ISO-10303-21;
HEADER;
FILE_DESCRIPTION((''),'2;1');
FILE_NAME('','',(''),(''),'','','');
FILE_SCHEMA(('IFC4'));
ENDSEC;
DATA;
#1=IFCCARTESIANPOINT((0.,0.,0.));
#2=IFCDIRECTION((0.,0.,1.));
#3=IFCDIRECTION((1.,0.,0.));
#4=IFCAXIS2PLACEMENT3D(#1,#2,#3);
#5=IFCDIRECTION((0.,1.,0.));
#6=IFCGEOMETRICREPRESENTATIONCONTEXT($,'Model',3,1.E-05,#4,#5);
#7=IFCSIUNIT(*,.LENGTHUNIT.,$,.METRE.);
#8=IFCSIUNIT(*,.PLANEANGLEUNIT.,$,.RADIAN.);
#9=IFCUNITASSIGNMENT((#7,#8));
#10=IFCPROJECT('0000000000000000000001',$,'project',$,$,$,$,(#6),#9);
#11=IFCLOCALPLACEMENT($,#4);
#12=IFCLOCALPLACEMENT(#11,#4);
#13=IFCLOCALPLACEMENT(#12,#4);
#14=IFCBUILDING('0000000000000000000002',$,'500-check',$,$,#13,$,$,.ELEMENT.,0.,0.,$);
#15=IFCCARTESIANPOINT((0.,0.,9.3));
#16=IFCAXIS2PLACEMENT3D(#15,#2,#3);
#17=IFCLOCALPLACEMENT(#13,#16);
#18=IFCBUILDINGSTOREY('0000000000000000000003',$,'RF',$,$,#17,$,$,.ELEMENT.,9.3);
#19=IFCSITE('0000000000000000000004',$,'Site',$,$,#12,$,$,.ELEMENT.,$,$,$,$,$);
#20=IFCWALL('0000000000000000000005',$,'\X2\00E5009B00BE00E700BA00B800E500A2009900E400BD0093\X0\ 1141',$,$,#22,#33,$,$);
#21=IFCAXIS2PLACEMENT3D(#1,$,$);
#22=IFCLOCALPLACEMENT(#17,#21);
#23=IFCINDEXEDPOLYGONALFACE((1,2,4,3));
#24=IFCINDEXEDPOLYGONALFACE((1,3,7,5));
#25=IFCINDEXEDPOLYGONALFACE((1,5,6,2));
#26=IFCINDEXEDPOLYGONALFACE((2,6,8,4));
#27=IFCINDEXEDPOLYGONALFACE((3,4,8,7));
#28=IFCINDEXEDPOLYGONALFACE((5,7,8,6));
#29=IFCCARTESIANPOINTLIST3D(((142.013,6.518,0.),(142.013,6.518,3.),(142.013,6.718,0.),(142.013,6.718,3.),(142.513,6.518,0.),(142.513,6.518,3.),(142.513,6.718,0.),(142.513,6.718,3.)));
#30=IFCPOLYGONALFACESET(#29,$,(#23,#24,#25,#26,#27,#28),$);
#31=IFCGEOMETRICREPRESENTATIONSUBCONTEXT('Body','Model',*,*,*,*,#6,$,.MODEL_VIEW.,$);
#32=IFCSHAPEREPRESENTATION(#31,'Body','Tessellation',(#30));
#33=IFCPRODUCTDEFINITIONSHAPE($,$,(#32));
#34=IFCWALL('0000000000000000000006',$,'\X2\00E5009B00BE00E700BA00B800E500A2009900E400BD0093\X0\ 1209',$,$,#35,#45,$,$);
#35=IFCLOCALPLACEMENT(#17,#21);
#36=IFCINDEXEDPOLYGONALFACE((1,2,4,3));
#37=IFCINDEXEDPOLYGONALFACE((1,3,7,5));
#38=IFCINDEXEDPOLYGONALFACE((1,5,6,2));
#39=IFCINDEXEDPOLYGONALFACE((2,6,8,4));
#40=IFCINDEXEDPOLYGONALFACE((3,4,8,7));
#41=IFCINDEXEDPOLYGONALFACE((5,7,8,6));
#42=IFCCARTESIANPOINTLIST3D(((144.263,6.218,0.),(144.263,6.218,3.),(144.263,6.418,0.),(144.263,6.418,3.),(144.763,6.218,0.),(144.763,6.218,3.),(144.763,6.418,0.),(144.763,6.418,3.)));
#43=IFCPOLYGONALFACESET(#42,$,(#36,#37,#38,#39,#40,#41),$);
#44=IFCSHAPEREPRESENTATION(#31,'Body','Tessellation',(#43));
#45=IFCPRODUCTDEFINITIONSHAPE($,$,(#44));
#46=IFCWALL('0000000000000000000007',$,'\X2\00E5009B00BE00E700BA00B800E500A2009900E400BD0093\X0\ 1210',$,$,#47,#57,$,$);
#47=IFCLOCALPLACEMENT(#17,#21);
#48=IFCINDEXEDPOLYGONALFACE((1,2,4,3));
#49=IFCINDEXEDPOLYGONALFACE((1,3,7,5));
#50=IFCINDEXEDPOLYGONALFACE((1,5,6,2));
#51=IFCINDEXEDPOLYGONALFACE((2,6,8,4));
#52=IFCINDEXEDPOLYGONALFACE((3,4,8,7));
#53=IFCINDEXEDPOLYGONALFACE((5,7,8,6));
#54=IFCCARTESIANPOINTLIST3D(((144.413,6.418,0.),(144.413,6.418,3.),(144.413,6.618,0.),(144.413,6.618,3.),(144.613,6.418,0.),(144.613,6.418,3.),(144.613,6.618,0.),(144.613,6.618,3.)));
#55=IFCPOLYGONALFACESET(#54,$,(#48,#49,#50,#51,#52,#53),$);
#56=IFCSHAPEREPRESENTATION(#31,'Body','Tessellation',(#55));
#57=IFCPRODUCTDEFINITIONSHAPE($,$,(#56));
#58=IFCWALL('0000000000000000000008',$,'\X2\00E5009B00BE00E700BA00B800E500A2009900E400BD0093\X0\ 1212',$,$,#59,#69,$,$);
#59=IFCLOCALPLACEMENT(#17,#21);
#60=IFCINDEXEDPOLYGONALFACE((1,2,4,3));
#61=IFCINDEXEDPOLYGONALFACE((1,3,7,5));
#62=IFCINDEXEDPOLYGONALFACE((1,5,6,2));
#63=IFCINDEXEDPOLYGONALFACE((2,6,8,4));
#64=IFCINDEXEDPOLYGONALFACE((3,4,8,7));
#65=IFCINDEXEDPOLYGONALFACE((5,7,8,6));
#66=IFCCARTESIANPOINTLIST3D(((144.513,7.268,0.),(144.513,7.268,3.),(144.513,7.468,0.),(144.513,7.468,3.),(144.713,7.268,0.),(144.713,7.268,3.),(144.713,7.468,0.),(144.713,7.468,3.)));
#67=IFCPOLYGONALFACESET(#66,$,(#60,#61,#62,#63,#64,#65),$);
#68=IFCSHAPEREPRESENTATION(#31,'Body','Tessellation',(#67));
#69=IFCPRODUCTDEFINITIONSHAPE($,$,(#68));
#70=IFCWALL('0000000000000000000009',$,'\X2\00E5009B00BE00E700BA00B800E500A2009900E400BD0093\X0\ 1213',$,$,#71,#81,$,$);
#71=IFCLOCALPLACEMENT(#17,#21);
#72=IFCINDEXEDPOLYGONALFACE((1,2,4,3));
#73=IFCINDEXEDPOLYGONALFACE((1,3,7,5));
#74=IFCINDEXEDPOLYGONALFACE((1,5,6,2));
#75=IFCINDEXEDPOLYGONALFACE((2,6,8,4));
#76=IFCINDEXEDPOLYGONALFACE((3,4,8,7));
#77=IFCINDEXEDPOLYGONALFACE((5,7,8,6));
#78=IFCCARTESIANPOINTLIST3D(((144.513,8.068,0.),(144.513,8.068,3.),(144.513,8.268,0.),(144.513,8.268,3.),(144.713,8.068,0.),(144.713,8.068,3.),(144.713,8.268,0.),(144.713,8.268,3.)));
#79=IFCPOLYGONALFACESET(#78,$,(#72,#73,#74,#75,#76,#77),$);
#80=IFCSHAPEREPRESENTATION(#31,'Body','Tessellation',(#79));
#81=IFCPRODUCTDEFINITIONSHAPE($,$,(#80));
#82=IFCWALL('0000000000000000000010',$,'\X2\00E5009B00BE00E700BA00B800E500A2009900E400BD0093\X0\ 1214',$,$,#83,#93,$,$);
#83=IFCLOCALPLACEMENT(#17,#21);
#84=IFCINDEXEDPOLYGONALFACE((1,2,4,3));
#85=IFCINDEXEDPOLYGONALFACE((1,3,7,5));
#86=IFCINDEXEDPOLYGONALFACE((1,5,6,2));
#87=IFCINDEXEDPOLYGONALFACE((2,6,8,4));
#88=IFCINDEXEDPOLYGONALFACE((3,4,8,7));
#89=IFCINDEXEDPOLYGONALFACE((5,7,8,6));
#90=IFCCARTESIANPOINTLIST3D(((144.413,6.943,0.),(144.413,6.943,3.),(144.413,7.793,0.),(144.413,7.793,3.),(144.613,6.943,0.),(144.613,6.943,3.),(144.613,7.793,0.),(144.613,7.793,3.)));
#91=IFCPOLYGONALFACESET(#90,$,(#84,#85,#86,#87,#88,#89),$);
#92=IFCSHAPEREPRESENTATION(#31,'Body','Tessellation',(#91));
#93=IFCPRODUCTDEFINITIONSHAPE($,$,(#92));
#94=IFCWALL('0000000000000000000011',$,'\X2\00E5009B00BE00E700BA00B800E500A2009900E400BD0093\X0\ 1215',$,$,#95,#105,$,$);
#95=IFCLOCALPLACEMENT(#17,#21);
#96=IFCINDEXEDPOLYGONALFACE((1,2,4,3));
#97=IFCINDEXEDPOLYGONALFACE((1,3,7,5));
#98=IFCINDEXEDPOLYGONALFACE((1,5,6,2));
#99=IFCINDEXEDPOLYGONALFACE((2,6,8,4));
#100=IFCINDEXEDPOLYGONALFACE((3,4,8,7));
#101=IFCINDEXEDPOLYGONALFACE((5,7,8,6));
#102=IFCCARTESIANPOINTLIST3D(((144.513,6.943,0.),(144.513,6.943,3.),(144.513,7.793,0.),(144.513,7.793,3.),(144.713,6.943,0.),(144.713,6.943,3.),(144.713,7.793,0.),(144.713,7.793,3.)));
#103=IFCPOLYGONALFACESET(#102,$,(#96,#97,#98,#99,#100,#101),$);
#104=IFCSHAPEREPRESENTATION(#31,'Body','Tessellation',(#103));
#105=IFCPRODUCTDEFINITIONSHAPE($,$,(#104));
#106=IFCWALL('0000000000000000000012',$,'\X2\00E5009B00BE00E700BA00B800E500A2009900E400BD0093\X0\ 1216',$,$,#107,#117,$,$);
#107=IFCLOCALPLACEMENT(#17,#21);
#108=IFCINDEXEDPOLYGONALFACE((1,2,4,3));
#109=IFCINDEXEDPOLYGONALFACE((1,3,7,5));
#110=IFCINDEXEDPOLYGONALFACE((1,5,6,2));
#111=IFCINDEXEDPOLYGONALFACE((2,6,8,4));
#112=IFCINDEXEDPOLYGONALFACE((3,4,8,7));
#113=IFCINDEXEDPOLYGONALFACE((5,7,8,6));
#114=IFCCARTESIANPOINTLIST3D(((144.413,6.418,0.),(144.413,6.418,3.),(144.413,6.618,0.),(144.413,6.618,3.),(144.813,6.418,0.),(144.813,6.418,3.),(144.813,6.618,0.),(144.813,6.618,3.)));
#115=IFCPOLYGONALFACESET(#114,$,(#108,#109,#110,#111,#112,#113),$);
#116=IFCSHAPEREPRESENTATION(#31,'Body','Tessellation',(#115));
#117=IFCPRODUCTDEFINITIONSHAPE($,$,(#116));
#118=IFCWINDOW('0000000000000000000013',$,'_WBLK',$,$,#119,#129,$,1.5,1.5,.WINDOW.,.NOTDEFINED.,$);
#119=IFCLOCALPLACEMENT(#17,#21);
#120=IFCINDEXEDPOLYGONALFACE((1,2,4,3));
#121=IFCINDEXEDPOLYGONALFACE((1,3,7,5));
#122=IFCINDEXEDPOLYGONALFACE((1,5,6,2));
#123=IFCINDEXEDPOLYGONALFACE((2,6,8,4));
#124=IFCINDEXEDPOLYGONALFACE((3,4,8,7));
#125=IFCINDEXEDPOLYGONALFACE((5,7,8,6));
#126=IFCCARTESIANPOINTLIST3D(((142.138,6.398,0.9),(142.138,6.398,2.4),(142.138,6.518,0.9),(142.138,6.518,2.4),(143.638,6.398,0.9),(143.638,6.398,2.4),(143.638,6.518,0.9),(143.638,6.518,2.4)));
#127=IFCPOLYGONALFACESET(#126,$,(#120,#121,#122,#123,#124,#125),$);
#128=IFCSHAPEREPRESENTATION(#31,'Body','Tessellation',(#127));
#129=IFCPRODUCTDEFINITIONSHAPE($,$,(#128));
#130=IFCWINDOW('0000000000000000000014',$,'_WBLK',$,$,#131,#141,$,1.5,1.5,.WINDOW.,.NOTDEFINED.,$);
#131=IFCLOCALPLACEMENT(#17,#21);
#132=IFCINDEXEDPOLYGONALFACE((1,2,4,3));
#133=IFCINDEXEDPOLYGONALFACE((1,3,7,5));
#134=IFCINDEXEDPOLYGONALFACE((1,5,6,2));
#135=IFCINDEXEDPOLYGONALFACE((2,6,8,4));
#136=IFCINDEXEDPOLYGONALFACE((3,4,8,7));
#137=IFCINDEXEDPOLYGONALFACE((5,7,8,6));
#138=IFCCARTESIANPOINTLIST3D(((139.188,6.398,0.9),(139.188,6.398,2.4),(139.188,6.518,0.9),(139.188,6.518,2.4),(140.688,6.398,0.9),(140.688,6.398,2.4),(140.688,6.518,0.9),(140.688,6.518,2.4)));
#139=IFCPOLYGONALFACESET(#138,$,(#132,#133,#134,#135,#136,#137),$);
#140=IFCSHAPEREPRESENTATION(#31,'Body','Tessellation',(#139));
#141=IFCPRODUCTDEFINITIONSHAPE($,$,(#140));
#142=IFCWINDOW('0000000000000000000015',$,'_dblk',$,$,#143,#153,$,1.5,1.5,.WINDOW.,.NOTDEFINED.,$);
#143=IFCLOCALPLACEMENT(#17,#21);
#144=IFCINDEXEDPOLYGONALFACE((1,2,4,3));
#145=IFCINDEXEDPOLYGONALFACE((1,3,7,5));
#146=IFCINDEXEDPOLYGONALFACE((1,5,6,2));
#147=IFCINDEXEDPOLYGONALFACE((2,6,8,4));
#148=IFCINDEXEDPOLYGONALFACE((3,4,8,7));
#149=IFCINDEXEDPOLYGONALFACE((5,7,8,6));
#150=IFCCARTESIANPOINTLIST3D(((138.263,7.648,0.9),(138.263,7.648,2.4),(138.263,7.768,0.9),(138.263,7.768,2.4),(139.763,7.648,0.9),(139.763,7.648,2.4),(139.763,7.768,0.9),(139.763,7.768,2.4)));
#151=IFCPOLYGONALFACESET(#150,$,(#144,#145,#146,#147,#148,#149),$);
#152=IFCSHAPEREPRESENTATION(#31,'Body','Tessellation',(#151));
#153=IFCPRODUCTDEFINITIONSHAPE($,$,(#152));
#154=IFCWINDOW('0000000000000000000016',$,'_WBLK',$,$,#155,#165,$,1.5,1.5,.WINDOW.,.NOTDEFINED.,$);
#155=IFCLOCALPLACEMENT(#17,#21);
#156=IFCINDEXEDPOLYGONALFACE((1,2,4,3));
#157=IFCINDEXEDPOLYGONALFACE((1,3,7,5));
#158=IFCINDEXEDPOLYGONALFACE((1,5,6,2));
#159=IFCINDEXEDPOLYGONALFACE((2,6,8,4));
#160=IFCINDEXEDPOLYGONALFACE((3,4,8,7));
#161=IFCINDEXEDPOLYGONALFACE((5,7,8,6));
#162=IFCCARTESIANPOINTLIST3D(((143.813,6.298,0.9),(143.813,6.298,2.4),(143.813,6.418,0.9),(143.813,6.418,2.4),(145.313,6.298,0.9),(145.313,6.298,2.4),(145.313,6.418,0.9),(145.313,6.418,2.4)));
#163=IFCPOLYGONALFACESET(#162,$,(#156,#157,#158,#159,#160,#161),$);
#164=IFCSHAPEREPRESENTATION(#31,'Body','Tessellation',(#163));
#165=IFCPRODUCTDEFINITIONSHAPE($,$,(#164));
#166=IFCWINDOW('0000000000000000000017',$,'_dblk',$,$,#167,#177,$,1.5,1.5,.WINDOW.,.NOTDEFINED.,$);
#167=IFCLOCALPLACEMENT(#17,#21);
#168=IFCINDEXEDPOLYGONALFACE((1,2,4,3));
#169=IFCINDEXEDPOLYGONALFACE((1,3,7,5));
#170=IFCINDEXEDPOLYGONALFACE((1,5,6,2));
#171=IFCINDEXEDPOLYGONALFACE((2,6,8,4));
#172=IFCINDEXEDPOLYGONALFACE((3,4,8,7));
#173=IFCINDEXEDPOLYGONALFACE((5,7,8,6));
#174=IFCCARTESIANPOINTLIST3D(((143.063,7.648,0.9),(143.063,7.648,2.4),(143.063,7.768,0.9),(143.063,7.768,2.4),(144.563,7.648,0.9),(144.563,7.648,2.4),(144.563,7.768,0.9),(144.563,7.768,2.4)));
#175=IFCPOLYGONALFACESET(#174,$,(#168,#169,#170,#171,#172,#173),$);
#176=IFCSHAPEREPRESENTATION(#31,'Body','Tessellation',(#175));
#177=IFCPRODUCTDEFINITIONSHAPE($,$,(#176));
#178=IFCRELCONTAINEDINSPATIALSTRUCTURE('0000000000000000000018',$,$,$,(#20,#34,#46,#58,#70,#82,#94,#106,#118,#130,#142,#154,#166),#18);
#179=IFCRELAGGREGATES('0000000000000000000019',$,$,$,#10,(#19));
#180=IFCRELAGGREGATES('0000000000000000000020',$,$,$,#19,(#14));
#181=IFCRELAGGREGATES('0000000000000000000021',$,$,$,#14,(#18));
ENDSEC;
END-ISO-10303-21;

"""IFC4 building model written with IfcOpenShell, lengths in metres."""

from ifc_helpers import new_model, si_unit, direction, frame, frame_2d, origin_with_axes, place, context, subcontext, project, spatial, rectangle, extrude, element, save


model = new_model("IFC4")

# Units and contexts
model_context = context("Model", 3, precision=1e-05, world=origin_with_axes(), true_north=direction((0.0, 1.0, 0.0)))
body_context = subcontext(model_context, "Body", "Model", "MODEL_VIEW")
ifc_project = project(units=[si_unit("LENGTHUNIT", "METRE"), si_unit("PLANEANGLEUNIT", "RADIAN")], contexts=[model_context])

# Site, building, storey
placement = place(None, origin_with_axes())
site_placement = place(placement, origin_with_axes())
site = spatial("IfcSite", under=ifc_project, at=site_placement, Name="Site", CompositionType="ELEMENT")
building_placement = place(site_placement, origin_with_axes())
building = spatial("IfcBuilding", under=site, at=building_placement, Name="500-check", CompositionType="ELEMENT", ElevationOfRefHeight=0.0, ElevationOfTerrain=0.0)
storey_placement = place(building_placement, frame((0.0, 0.0, 9.3), z_axis=(0.0, 0.0, 1.0), x_axis=(1.0, 0.0, 0.0)))
storey = spatial("IfcBuildingStorey", under=building, at=storey_placement, Name="RF", CompositionType="ELEMENT", Elevation=9.3)

# Walls
for number, where, z_axis, x_axis, name in (
    (1, (142.263, 6.618, 0.0), (0.0, 0.0, 1.0), (1.0, 0.0, 0.0), "å\u009b¾çº¸å¢\u0099ä½\u0093 1141"),
    (2, (144.513, 6.318, 0.0), (0.0, 0.0, 1.0), (1.0, 0.0, 0.0), "å\u009b¾çº¸å¢\u0099ä½\u0093 1209"),
):
    element("IfcWall", number, at=place(storey_placement, frame(where, z_axis=z_axis, x_axis=x_axis)), inside=storey, Name=name, context=body_context, shape_type="SweptSolid", body=[
        extrude(rectangle(XDim=0.5, YDim=0.2, at=frame_2d((0.0, 0.0), x_axis=(1.0, 0.0, 0.0))), frame((0.0, 0.0, 0.0), z_axis=(0.0, 0.0, 1.0)), (0.0, 0.0, 1.0), 3.0),
    ])
for number, where, z_axis, x_axis, name in (
    (3, (144.513, 6.518, 0.0), (0.0, 0.0, 1.0), (0.0, -1.0, 0.0), "å\u009b¾çº¸å¢\u0099ä½\u0093 1210"),
    (4, (144.613, 7.368, 0.0), (0.0, 0.0, 1.0), (-1.0, 0.0, 0.0), "å\u009b¾çº¸å¢\u0099ä½\u0093 1212"),
    (5, (144.613, 8.168, 0.0), (0.0, 0.0, 1.0), (-1.0, 0.0, 0.0), "å\u009b¾çº¸å¢\u0099ä½\u0093 1213"),
):
    element("IfcWall", number, at=place(storey_placement, frame(where, z_axis=z_axis, x_axis=x_axis)), inside=storey, Name=name, context=body_context, shape_type="SweptSolid", body=[
        extrude(rectangle(XDim=0.2, YDim=0.2, at=frame_2d((0.0, 0.0), x_axis=(1.0, 0.0, 0.0))), frame((0.0, 0.0, 0.0), z_axis=(0.0, 0.0, 1.0)), (0.0, 0.0, 1.0), 3.0),
    ])
for number, where, z_axis, x_axis, name in (
    (6, (144.513, 7.368, 0.0), (0.0, 0.0, 1.0), (0.0, -1.0, 0.0), "å\u009b¾çº¸å¢\u0099ä½\u0093 1214"),
    (7, (144.613, 7.368, 0.0), (0.0, 0.0, 1.0), (0.0, -1.0, 0.0), "å\u009b¾çº¸å¢\u0099ä½\u0093 1215"),
):
    element("IfcWall", number, at=place(storey_placement, frame(where, z_axis=z_axis, x_axis=x_axis)), inside=storey, Name=name, context=body_context, shape_type="SweptSolid", body=[
        extrude(rectangle(XDim=0.85, YDim=0.2, at=frame_2d((0.0, 0.0), x_axis=(1.0, 0.0, 0.0))), frame((0.0, 0.0, 0.0), z_axis=(0.0, 0.0, 1.0)), (0.0, 0.0, 1.0), 3.0),
    ])
wall_1_placement = place(storey_placement, frame((144.613, 6.518, 0.0), z_axis=(0.0, 0.0, 1.0), x_axis=(1.0, 0.0, 0.0)))
element("IfcWall", 8, at=wall_1_placement, inside=storey, Name="å\u009b¾çº¸å¢\u0099ä½\u0093 1216", context=body_context, shape_type="SweptSolid", body=[
    extrude(rectangle(XDim=0.4, YDim=0.2, at=frame_2d((0.0, 0.0), x_axis=(1.0, 0.0, 0.0))), frame((0.0, 0.0, 0.0), z_axis=(0.0, 0.0, 1.0)), (0.0, 0.0, 1.0), 3.0),
])

# Windows
for number, where, z_axis, x_axis, name in (
    (9, (142.888, 6.458, 0.9), (0.0, 0.0, 1.0), (1.0, 0.0, 0.0), "_WBLK"),
    (10, (139.938, 6.458, 0.9), (0.0, 0.0, 1.0), (1.0, 0.0, 0.0), "_WBLK"),
    (11, (139.013, 7.708, 0.9), (0.0, 0.0, 1.0), (1.0, 0.0, 0.0), "_dblk"),
    (12, (144.563, 6.358, 0.9), (0.0, 0.0, 1.0), (1.0, 0.0, 0.0), "_WBLK"),
    (13, (143.813, 7.708, 0.9), (0.0, 0.0, 1.0), (1.0, 0.0, 0.0), "_dblk"),
):
    element("IfcWindow", number, at=place(storey_placement, frame(where, z_axis=z_axis, x_axis=x_axis)), inside=storey, Name=name, OverallHeight=1.5, OverallWidth=1.5, PartitioningType="NOTDEFINED", PredefinedType="WINDOW", context=body_context, shape_type="SweptSolid", body=[
        extrude(rectangle(XDim=1.5, YDim=0.12, at=frame_2d((0.0, 0.0), x_axis=(1.0, 0.0, 0.0))), frame((0.0, 0.0, 0.0), z_axis=(0.0, 0.0, 1.0)), (0.0, 0.0, 1.0), 1.5),
    ])

save(model, "model.ifc")
